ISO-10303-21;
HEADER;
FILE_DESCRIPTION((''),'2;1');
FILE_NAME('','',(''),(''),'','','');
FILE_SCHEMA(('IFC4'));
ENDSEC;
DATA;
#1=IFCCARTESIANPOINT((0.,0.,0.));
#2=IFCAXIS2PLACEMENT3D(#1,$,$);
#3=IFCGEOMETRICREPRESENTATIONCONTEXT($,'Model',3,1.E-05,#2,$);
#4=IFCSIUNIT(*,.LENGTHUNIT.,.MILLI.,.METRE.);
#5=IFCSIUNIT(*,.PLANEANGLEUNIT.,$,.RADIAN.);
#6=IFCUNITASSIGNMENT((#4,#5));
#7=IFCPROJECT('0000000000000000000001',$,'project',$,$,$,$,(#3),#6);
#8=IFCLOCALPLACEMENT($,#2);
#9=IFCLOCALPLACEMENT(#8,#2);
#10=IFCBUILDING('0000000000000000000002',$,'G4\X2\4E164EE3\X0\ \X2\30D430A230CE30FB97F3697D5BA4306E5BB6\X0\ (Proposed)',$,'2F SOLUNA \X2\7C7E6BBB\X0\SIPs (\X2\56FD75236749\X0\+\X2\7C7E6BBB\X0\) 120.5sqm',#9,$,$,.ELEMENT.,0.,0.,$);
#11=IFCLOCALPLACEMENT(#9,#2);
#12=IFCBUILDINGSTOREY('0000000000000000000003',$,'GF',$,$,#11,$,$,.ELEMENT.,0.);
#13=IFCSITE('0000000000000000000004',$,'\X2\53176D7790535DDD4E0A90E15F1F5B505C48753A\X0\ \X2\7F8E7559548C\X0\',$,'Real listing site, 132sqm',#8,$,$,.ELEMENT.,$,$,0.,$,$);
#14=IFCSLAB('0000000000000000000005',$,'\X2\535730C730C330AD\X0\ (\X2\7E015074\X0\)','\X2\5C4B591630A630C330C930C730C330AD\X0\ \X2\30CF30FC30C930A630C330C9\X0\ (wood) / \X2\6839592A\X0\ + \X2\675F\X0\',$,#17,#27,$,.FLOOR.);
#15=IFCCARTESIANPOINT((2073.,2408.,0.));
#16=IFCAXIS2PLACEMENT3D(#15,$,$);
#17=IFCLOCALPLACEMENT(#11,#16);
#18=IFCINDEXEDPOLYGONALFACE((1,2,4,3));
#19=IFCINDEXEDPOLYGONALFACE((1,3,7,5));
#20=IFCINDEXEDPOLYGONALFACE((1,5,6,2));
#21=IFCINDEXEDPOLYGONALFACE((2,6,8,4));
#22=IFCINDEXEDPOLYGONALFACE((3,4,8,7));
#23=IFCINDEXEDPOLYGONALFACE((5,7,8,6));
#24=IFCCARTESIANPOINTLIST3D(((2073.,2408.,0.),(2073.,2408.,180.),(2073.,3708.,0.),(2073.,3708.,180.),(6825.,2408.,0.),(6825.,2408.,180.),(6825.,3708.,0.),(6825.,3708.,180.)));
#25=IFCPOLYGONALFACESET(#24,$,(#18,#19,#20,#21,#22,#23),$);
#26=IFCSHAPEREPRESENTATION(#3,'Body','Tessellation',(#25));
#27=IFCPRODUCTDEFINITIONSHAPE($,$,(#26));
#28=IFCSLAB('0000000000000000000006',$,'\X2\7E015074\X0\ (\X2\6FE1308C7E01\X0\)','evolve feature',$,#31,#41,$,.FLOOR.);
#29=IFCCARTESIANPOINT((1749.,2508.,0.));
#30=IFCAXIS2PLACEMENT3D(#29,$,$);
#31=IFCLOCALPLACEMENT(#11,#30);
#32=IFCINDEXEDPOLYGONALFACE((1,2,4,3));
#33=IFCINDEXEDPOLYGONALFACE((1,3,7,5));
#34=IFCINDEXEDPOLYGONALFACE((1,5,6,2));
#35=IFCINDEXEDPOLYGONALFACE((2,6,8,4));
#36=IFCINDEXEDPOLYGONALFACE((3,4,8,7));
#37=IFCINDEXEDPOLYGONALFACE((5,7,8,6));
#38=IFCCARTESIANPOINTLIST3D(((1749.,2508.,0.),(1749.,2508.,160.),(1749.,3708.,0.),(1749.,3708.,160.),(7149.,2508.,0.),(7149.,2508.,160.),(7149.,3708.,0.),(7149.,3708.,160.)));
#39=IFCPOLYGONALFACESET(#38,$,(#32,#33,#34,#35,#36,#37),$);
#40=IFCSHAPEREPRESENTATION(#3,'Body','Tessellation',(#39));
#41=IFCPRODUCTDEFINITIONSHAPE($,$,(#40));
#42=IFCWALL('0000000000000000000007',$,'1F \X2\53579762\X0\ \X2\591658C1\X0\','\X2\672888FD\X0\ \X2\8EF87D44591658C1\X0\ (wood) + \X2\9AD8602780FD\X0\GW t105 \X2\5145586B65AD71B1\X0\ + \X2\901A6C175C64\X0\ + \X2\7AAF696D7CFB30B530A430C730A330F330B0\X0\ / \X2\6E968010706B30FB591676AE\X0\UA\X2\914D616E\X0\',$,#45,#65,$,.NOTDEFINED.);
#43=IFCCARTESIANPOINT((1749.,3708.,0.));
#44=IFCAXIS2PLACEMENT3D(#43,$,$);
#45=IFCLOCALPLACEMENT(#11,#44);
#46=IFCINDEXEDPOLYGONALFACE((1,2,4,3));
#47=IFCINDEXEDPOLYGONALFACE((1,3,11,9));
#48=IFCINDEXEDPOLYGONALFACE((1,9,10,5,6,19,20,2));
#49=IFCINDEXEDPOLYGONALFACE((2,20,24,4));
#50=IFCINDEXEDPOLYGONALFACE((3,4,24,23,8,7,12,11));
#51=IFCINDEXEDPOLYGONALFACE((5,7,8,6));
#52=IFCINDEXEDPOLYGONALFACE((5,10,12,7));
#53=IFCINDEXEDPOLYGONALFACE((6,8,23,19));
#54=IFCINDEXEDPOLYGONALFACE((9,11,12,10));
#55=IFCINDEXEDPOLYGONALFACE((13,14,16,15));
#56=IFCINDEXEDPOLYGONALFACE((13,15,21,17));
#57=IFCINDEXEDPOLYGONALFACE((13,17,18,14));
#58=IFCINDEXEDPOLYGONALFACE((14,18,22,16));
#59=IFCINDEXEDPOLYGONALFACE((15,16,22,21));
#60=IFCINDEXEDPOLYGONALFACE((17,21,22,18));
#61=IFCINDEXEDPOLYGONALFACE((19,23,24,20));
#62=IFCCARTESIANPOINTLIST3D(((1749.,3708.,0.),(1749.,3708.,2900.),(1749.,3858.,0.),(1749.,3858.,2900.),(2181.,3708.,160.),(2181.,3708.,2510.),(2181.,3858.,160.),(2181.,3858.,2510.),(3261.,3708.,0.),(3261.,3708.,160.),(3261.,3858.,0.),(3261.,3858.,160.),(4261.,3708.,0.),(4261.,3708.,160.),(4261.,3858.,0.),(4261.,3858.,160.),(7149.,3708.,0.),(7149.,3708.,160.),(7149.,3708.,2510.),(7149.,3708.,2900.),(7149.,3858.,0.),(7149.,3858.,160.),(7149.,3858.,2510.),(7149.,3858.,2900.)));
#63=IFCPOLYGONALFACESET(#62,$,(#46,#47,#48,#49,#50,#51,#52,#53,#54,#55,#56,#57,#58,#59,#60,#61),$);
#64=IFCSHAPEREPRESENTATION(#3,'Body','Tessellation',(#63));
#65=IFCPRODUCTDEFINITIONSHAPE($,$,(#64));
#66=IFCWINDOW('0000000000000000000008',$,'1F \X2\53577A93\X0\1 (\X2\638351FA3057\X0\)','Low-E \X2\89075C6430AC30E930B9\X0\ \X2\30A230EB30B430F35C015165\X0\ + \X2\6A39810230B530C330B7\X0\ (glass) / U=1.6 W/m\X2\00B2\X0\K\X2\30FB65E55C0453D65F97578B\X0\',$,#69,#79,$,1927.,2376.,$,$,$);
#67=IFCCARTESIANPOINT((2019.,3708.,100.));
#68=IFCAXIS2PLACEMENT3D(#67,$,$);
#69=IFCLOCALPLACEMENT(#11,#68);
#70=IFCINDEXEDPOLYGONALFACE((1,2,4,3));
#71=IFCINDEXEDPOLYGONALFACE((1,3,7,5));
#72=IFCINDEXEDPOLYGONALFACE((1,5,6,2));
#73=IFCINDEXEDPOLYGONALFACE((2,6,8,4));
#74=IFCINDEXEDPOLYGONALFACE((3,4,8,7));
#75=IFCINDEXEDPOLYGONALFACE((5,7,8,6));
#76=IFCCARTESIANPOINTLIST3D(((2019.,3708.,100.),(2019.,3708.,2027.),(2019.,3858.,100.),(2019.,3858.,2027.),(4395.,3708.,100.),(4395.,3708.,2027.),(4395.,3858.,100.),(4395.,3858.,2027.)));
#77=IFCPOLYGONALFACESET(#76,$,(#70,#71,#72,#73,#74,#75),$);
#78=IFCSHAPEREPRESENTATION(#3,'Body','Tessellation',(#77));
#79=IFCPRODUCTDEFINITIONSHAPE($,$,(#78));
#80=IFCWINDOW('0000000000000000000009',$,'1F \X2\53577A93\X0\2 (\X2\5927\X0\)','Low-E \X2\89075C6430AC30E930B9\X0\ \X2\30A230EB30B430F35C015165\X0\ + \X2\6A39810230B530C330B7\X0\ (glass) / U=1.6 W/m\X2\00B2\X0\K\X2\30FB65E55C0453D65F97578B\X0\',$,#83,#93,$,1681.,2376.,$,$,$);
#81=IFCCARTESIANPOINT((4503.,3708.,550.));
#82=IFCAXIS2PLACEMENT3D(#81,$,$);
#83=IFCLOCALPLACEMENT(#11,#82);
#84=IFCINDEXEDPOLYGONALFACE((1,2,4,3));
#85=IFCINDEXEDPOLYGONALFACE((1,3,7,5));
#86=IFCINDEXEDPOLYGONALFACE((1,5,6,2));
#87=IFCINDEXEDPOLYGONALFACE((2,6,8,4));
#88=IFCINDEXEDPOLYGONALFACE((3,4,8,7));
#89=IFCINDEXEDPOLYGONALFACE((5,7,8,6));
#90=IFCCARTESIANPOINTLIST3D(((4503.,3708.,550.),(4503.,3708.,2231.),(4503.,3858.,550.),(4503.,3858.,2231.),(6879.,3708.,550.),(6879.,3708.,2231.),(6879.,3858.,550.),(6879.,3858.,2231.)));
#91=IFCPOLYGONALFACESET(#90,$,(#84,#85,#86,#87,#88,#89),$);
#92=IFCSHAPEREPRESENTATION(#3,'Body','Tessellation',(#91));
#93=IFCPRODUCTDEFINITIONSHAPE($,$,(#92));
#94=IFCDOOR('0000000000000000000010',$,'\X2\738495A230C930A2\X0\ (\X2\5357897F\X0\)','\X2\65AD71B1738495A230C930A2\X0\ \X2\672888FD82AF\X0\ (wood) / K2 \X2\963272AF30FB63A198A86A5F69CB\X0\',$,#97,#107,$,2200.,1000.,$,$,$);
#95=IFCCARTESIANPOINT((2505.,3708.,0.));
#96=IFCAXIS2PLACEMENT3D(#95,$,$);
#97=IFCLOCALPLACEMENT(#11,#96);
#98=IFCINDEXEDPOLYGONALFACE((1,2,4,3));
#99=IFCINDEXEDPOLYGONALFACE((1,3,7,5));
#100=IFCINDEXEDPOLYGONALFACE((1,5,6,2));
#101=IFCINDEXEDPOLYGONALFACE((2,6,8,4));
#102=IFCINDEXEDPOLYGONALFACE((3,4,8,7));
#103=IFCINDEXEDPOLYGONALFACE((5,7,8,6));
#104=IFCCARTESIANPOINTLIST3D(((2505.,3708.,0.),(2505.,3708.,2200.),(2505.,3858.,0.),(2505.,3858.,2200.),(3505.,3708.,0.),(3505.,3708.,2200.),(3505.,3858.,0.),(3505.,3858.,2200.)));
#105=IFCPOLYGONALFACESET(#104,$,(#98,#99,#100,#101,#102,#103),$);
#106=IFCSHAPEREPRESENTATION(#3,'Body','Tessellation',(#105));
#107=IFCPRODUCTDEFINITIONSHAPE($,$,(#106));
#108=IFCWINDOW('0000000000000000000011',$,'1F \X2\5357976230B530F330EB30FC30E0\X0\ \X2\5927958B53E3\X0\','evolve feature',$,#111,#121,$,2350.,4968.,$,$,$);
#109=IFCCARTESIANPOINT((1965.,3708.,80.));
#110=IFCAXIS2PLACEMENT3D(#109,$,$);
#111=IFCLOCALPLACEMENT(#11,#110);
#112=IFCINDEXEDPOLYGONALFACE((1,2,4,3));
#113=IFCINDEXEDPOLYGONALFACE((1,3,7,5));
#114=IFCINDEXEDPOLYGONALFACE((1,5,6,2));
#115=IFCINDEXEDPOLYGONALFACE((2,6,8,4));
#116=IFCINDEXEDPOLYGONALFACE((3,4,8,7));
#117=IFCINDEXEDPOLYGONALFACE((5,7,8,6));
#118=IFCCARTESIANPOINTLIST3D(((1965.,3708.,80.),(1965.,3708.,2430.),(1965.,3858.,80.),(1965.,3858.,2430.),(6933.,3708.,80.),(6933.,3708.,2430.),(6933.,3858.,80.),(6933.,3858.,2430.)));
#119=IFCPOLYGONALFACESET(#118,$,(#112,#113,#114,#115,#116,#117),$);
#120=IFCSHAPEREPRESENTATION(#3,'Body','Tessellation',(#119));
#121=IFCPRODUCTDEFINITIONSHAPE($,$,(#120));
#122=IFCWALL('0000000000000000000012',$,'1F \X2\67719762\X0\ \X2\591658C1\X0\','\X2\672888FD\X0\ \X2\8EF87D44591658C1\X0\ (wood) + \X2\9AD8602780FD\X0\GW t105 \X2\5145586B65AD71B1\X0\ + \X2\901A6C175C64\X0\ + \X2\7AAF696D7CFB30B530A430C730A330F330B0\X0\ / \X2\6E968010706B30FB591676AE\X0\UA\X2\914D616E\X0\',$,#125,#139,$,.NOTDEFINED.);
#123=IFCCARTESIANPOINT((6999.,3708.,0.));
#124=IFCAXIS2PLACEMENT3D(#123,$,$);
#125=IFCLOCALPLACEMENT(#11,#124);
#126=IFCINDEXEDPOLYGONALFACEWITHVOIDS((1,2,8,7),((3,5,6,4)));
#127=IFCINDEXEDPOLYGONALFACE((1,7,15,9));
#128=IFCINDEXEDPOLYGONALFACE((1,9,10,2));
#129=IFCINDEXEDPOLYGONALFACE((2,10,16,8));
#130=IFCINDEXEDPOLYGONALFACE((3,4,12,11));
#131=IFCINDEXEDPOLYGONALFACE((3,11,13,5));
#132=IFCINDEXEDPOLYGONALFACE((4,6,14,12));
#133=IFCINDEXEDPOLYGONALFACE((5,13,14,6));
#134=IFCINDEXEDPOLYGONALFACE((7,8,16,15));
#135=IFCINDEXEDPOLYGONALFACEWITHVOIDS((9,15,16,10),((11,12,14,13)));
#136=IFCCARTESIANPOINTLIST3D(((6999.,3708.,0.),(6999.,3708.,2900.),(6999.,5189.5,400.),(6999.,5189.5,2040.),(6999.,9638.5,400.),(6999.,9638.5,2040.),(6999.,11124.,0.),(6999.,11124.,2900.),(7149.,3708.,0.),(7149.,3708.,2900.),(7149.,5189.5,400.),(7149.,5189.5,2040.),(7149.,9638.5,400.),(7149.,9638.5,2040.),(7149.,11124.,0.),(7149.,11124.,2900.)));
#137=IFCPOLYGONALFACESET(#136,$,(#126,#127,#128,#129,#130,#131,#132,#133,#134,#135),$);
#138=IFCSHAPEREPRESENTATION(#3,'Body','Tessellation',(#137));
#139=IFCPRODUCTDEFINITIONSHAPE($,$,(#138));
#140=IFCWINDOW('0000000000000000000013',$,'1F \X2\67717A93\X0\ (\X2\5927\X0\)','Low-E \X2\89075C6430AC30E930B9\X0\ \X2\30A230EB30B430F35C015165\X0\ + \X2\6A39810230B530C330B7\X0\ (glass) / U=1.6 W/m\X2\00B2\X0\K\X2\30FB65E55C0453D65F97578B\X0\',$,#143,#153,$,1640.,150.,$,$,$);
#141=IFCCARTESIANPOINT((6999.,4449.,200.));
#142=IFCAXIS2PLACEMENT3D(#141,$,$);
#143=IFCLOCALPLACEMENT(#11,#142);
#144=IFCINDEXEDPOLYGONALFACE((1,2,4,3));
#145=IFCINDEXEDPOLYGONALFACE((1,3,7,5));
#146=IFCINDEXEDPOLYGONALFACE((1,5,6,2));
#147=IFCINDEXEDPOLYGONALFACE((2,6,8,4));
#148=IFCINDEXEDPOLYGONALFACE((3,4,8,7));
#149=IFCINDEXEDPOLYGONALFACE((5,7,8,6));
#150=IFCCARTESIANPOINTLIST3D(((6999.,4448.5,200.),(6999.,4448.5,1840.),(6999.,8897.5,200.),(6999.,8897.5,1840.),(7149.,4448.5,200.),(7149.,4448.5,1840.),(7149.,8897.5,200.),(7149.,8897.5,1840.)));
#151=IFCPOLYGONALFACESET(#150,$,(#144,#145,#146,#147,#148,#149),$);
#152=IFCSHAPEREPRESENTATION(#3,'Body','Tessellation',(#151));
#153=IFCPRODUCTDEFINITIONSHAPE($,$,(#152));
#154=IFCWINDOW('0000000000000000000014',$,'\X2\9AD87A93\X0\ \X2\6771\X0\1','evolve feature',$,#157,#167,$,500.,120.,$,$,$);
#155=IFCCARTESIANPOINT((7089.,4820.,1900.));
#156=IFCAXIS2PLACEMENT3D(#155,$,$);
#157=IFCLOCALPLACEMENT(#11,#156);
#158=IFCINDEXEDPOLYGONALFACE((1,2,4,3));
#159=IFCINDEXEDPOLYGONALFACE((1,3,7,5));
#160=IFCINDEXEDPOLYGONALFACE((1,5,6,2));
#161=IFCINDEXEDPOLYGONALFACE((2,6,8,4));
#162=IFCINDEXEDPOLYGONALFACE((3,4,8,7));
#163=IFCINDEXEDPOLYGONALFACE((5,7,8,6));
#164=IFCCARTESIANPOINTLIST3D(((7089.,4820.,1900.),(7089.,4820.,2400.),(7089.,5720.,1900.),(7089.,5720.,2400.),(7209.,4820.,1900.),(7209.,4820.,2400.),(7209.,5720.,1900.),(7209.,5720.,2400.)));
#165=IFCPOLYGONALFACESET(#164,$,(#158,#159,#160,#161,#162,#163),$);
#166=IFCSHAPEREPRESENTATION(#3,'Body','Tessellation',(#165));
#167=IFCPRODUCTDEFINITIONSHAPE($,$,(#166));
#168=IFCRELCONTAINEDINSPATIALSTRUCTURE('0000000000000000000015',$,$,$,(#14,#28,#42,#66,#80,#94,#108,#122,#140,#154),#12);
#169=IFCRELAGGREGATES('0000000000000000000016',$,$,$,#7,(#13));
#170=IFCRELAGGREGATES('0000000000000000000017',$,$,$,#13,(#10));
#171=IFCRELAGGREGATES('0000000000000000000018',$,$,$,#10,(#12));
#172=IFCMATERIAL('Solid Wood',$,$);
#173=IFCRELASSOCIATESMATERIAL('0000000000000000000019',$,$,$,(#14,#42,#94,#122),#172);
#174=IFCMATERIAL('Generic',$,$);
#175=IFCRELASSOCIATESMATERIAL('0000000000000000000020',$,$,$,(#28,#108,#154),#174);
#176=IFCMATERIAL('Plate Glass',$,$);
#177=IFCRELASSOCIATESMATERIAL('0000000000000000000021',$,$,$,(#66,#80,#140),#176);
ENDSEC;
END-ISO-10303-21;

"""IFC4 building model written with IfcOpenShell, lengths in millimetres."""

from ifc_helpers import new_model, si_unit, frame, frame_2d, origin, place, context, project, spatial, rectangle, extrude, material, element, fill, save


model = new_model("IFC4")

# Units and contexts
model_context = context("Model", 3, precision=1e-05, world=origin())
ifc_project = project(units=[si_unit("LENGTHUNIT", "METRE", prefix="MILLI"), si_unit("PLANEANGLEUNIT", "RADIAN")], contexts=[model_context])

# Site, building, storey
site_placement = place(None, origin())
site = spatial("IfcSite", under=ifc_project, at=site_placement, Name="北海道川上郡弟子屈町 美留和", ObjectType="Real listing site, 132sqm", CompositionType="ELEMENT", RefElevation=0.0)
building_placement = place(site_placement, origin())
building = spatial("IfcBuilding", under=site, at=building_placement, Name="G4世代 ピアノ・音楽室の家 (Proposed)", ObjectType="2F SOLUNA 籾殻SIPs (国産杉+籾殻) 120.5sqm", CompositionType="ELEMENT", ElevationOfRefHeight=0.0, ElevationOfTerrain=0.0)
storey_placement = place(building_placement, origin())
storey = spatial("IfcBuildingStorey", under=building, at=storey_placement, Name="GF", CompositionType="ELEMENT", Elevation=0.0)

# Slabs
ifc_material_1 = material(Name="Solid Wood")
slab_1_placement = place(storey_placement, frame((2073.0, 2408.0, 0.0)))
element("IfcSlab", 1, at=slab_1_placement, inside=storey, material=ifc_material_1, Name="南デッキ (縁側)", Description="屋外ウッドデッキ ハードウッド (wood) / 根太 + 束", PredefinedType="FLOOR", context=model_context, shape_type="SweptSolid", body=[
    extrude(rectangle(XDim=4752.0, YDim=1300.0, at=frame_2d((2376.0, 650.0))), frame((2073.0, 2408.0, 0.0)), (0.0, 0.0, 1.0), 180.0),
])
ifc_material_2 = material(Name="Generic")
slab_2_placement = place(storey_placement, frame((1749.0, 2508.0, 0.0)))
element("IfcSlab", 2, at=slab_2_placement, inside=storey, material=ifc_material_2, Name="縁側 (濡れ縁)", Description="evolve feature", PredefinedType="FLOOR", context=model_context, shape_type="SweptSolid", body=[
    extrude(rectangle(XDim=5400.0, YDim=1200.0, at=frame_2d((2700.0, 600.0))), frame((1749.0, 2508.0, 0.0)), (0.0, 0.0, 1.0), 160.0),
])

# Wall, openings, windows, door
wall_1_placement = place(storey_placement, frame((1749.0, 3708.0, 0.0)))
wall_1 = element("IfcWall", 3, at=wall_1_placement, inside=storey, material=ifc_material_1, Name="1F 南面 外壁", Description="木製 軸組外壁 (wood) + 高性能GW t105 充填断熱 + 通気層 + 窯業系サイディング / 準耐火・外皮UA配慮", PredefinedType="NOTDEFINED", context=model_context, shape_type="SweptSolid", body=[
    extrude(rectangle(XDim=5400.0, YDim=150.0, at=frame_2d((2700.0, 75.0))), frame((1749.0, 3708.0, 0.0)), (0.0, 0.0, 1.0), 2900.0),
])
opening_1_placement = place(storey_placement, frame((2019.0, 3708.0, 100.0)))
opening_1 = element("IfcOpeningElement", 4, at=opening_1_placement, cuts=wall_1, PredefinedType="NOTDEFINED", context=model_context, shape_type="SweptSolid", body=[
    extrude(rectangle(XDim=2376.0, YDim=150.0, at=frame_2d((1188.0, 75.0))), frame((2019.0, 3708.0, 100.0)), (0.0, 0.0, 1.0), 1927.0),
])
opening_2_placement = place(storey_placement, frame((4503.0, 3708.0, 550.0)))
opening_2 = element("IfcOpeningElement", 5, at=opening_2_placement, cuts=wall_1, PredefinedType="NOTDEFINED", context=model_context, shape_type="SweptSolid", body=[
    extrude(rectangle(XDim=2376.0, YDim=150.0, at=frame_2d((1188.0, 75.0))), frame((4503.0, 3708.0, 550.0)), (0.0, 0.0, 1.0), 1681.0),
])
opening_3_placement = place(storey_placement, frame((2505.0, 3708.0, 0.0)))
opening_3 = element("IfcOpeningElement", 6, at=opening_3_placement, cuts=wall_1, PredefinedType="NOTDEFINED", context=model_context, shape_type="SweptSolid", body=[
    extrude(rectangle(XDim=1000.0, YDim=150.0, at=frame_2d((500.0, 75.0))), frame((2505.0, 3708.0, 0.0)), (0.0, 0.0, 1.0), 2200.0),
])
opening_4_placement = place(storey_placement, frame((1965.0, 3708.0, 80.0)))
opening_4 = element("IfcOpeningElement", 7, at=opening_4_placement, cuts=wall_1, PredefinedType="NOTDEFINED", context=model_context, shape_type="SweptSolid", body=[
    extrude(rectangle(XDim=4968.0, YDim=150.0, at=frame_2d((2484.0, 75.0))), frame((1965.0, 3708.0, 80.0)), (0.0, 0.0, 1.0), 2350.0),
])
ifc_material_3 = material(Name="Plate Glass")
window_1_placement = place(storey_placement, frame((2019.0, 3708.0, 100.0)))
window_1 = element("IfcWindow", 8, at=window_1_placement, inside=storey, material=ifc_material_3, Name="1F 南窓1 (掃出し)", Description="Low-E 複層ガラス アルゴン封入 + 樹脂サッシ (glass) / U=1.6 W/m²K・日射取得型", OverallHeight=1927.0, OverallWidth=2376.0, context=model_context, shape_type="SweptSolid", body=[
    extrude(rectangle(XDim=2376.0, YDim=150.0, at=frame_2d((1188.0, 75.0))), frame((2019.0, 3708.0, 100.0)), (0.0, 0.0, 1.0), 1927.0),
])
fill(opening_1, window_1)
window_2_placement = place(storey_placement, frame((4503.0, 3708.0, 550.0)))
window_2 = element("IfcWindow", 9, at=window_2_placement, inside=storey, material=ifc_material_3, Name="1F 南窓2 (大)", Description="Low-E 複層ガラス アルゴン封入 + 樹脂サッシ (glass) / U=1.6 W/m²K・日射取得型", OverallHeight=1681.0, OverallWidth=2376.0, context=model_context, shape_type="SweptSolid", body=[
    extrude(rectangle(XDim=2376.0, YDim=150.0, at=frame_2d((1188.0, 75.0))), frame((4503.0, 3708.0, 550.0)), (0.0, 0.0, 1.0), 1681.0),
])
fill(opening_2, window_2)
door_placement = place(storey_placement, frame((2505.0, 3708.0, 0.0)))
door = element("IfcDoor", 10, at=door_placement, inside=storey, material=ifc_material_1, Name="玄関ドア (南西)", Description="断熱玄関ドア 木製芯 (wood) / K2 防犯・採風機構", OverallHeight=2200.0, OverallWidth=1000.0, context=model_context, shape_type="SweptSolid", body=[
    extrude(rectangle(XDim=1000.0, YDim=150.0, at=frame_2d((500.0, 75.0))), frame((2505.0, 3708.0, 0.0)), (0.0, 0.0, 1.0), 2200.0),
])
fill(opening_3, door)
window_3_placement = place(storey_placement, frame((1965.0, 3708.0, 80.0)))
window_3 = element("IfcWindow", 11, at=window_3_placement, inside=storey, material=ifc_material_2, Name="1F 南面サンルーム 大開口", Description="evolve feature", OverallHeight=2350.0, OverallWidth=4968.0, context=model_context, shape_type="SweptSolid", body=[
    extrude(rectangle(XDim=4968.0, YDim=150.0, at=frame_2d((2484.0, 75.0))), frame((1965.0, 3708.0, 80.0)), (0.0, 0.0, 1.0), 2350.0),
])
fill(opening_4, window_3)

# Wall, openings, windows
wall_2_placement = place(storey_placement, frame((6999.0, 3708.0, 0.0)))
wall_2 = element("IfcWall", 12, at=wall_2_placement, inside=storey, material=ifc_material_1, Name="1F 東面 外壁", Description="木製 軸組外壁 (wood) + 高性能GW t105 充填断熱 + 通気層 + 窯業系サイディング / 準耐火・外皮UA配慮", PredefinedType="NOTDEFINED", context=model_context, shape_type="SweptSolid", body=[
    extrude(rectangle(XDim=150.0, YDim=7416.0, at=frame_2d((75.0, 3708.0))), frame((6999.0, 3708.0, 0.0)), (0.0, 0.0, 1.0), 2900.0),
])
opening_5_placement = place(storey_placement, frame((6999.0, 4449.0, 200.0)))
opening_5 = element("IfcOpeningElement", 13, at=opening_5_placement, cuts=wall_2, PredefinedType="NOTDEFINED", context=model_context, shape_type="SweptSolid", body=[
    extrude(rectangle(XDim=150.0, YDim=4449.0, at=frame_2d((75.0, 2224.0))), frame((6999.0, 4449.0, 200.0)), (0.0, 0.0, 1.0), 1640.0),
])
opening_6_placement = place(storey_placement, frame((7089.0, 4820.0, 1900.0)))
opening_6 = element("IfcOpeningElement", 14, at=opening_6_placement, cuts=wall_2, PredefinedType="NOTDEFINED", context=model_context, shape_type="SweptSolid", body=[
    extrude(rectangle(XDim=120.0, YDim=900.0, at=frame_2d((60.0, 450.0))), frame((7089.0, 4820.0, 1900.0)), (0.0, 0.0, 1.0), 500.0),
])
window_4_placement = place(storey_placement, frame((6999.0, 4449.0, 200.0)))
window_4 = element("IfcWindow", 15, at=window_4_placement, inside=storey, material=ifc_material_3, Name="1F 東窓 (大)", Description="Low-E 複層ガラス アルゴン封入 + 樹脂サッシ (glass) / U=1.6 W/m²K・日射取得型", OverallHeight=1640.0, OverallWidth=150.0, context=model_context, shape_type="SweptSolid", body=[
    extrude(rectangle(XDim=150.0, YDim=4449.0, at=frame_2d((75.0, 2224.0))), frame((6999.0, 4449.0, 200.0)), (0.0, 0.0, 1.0), 1640.0),
])
fill(opening_5, window_4)
window_5_placement = place(storey_placement, frame((7089.0, 4820.0, 1900.0)))
window_5 = element("IfcWindow", 16, at=window_5_placement, inside=storey, material=ifc_material_2, Name="高窓 東1", Description="evolve feature", OverallHeight=500.0, OverallWidth=120.0, context=model_context, shape_type="SweptSolid", body=[
    extrude(rectangle(XDim=120.0, YDim=900.0, at=frame_2d((60.0, 450.0))), frame((7089.0, 4820.0, 1900.0)), (0.0, 0.0, 1.0), 500.0),
])
fill(opening_6, window_5)

save(model, "model.ifc")
